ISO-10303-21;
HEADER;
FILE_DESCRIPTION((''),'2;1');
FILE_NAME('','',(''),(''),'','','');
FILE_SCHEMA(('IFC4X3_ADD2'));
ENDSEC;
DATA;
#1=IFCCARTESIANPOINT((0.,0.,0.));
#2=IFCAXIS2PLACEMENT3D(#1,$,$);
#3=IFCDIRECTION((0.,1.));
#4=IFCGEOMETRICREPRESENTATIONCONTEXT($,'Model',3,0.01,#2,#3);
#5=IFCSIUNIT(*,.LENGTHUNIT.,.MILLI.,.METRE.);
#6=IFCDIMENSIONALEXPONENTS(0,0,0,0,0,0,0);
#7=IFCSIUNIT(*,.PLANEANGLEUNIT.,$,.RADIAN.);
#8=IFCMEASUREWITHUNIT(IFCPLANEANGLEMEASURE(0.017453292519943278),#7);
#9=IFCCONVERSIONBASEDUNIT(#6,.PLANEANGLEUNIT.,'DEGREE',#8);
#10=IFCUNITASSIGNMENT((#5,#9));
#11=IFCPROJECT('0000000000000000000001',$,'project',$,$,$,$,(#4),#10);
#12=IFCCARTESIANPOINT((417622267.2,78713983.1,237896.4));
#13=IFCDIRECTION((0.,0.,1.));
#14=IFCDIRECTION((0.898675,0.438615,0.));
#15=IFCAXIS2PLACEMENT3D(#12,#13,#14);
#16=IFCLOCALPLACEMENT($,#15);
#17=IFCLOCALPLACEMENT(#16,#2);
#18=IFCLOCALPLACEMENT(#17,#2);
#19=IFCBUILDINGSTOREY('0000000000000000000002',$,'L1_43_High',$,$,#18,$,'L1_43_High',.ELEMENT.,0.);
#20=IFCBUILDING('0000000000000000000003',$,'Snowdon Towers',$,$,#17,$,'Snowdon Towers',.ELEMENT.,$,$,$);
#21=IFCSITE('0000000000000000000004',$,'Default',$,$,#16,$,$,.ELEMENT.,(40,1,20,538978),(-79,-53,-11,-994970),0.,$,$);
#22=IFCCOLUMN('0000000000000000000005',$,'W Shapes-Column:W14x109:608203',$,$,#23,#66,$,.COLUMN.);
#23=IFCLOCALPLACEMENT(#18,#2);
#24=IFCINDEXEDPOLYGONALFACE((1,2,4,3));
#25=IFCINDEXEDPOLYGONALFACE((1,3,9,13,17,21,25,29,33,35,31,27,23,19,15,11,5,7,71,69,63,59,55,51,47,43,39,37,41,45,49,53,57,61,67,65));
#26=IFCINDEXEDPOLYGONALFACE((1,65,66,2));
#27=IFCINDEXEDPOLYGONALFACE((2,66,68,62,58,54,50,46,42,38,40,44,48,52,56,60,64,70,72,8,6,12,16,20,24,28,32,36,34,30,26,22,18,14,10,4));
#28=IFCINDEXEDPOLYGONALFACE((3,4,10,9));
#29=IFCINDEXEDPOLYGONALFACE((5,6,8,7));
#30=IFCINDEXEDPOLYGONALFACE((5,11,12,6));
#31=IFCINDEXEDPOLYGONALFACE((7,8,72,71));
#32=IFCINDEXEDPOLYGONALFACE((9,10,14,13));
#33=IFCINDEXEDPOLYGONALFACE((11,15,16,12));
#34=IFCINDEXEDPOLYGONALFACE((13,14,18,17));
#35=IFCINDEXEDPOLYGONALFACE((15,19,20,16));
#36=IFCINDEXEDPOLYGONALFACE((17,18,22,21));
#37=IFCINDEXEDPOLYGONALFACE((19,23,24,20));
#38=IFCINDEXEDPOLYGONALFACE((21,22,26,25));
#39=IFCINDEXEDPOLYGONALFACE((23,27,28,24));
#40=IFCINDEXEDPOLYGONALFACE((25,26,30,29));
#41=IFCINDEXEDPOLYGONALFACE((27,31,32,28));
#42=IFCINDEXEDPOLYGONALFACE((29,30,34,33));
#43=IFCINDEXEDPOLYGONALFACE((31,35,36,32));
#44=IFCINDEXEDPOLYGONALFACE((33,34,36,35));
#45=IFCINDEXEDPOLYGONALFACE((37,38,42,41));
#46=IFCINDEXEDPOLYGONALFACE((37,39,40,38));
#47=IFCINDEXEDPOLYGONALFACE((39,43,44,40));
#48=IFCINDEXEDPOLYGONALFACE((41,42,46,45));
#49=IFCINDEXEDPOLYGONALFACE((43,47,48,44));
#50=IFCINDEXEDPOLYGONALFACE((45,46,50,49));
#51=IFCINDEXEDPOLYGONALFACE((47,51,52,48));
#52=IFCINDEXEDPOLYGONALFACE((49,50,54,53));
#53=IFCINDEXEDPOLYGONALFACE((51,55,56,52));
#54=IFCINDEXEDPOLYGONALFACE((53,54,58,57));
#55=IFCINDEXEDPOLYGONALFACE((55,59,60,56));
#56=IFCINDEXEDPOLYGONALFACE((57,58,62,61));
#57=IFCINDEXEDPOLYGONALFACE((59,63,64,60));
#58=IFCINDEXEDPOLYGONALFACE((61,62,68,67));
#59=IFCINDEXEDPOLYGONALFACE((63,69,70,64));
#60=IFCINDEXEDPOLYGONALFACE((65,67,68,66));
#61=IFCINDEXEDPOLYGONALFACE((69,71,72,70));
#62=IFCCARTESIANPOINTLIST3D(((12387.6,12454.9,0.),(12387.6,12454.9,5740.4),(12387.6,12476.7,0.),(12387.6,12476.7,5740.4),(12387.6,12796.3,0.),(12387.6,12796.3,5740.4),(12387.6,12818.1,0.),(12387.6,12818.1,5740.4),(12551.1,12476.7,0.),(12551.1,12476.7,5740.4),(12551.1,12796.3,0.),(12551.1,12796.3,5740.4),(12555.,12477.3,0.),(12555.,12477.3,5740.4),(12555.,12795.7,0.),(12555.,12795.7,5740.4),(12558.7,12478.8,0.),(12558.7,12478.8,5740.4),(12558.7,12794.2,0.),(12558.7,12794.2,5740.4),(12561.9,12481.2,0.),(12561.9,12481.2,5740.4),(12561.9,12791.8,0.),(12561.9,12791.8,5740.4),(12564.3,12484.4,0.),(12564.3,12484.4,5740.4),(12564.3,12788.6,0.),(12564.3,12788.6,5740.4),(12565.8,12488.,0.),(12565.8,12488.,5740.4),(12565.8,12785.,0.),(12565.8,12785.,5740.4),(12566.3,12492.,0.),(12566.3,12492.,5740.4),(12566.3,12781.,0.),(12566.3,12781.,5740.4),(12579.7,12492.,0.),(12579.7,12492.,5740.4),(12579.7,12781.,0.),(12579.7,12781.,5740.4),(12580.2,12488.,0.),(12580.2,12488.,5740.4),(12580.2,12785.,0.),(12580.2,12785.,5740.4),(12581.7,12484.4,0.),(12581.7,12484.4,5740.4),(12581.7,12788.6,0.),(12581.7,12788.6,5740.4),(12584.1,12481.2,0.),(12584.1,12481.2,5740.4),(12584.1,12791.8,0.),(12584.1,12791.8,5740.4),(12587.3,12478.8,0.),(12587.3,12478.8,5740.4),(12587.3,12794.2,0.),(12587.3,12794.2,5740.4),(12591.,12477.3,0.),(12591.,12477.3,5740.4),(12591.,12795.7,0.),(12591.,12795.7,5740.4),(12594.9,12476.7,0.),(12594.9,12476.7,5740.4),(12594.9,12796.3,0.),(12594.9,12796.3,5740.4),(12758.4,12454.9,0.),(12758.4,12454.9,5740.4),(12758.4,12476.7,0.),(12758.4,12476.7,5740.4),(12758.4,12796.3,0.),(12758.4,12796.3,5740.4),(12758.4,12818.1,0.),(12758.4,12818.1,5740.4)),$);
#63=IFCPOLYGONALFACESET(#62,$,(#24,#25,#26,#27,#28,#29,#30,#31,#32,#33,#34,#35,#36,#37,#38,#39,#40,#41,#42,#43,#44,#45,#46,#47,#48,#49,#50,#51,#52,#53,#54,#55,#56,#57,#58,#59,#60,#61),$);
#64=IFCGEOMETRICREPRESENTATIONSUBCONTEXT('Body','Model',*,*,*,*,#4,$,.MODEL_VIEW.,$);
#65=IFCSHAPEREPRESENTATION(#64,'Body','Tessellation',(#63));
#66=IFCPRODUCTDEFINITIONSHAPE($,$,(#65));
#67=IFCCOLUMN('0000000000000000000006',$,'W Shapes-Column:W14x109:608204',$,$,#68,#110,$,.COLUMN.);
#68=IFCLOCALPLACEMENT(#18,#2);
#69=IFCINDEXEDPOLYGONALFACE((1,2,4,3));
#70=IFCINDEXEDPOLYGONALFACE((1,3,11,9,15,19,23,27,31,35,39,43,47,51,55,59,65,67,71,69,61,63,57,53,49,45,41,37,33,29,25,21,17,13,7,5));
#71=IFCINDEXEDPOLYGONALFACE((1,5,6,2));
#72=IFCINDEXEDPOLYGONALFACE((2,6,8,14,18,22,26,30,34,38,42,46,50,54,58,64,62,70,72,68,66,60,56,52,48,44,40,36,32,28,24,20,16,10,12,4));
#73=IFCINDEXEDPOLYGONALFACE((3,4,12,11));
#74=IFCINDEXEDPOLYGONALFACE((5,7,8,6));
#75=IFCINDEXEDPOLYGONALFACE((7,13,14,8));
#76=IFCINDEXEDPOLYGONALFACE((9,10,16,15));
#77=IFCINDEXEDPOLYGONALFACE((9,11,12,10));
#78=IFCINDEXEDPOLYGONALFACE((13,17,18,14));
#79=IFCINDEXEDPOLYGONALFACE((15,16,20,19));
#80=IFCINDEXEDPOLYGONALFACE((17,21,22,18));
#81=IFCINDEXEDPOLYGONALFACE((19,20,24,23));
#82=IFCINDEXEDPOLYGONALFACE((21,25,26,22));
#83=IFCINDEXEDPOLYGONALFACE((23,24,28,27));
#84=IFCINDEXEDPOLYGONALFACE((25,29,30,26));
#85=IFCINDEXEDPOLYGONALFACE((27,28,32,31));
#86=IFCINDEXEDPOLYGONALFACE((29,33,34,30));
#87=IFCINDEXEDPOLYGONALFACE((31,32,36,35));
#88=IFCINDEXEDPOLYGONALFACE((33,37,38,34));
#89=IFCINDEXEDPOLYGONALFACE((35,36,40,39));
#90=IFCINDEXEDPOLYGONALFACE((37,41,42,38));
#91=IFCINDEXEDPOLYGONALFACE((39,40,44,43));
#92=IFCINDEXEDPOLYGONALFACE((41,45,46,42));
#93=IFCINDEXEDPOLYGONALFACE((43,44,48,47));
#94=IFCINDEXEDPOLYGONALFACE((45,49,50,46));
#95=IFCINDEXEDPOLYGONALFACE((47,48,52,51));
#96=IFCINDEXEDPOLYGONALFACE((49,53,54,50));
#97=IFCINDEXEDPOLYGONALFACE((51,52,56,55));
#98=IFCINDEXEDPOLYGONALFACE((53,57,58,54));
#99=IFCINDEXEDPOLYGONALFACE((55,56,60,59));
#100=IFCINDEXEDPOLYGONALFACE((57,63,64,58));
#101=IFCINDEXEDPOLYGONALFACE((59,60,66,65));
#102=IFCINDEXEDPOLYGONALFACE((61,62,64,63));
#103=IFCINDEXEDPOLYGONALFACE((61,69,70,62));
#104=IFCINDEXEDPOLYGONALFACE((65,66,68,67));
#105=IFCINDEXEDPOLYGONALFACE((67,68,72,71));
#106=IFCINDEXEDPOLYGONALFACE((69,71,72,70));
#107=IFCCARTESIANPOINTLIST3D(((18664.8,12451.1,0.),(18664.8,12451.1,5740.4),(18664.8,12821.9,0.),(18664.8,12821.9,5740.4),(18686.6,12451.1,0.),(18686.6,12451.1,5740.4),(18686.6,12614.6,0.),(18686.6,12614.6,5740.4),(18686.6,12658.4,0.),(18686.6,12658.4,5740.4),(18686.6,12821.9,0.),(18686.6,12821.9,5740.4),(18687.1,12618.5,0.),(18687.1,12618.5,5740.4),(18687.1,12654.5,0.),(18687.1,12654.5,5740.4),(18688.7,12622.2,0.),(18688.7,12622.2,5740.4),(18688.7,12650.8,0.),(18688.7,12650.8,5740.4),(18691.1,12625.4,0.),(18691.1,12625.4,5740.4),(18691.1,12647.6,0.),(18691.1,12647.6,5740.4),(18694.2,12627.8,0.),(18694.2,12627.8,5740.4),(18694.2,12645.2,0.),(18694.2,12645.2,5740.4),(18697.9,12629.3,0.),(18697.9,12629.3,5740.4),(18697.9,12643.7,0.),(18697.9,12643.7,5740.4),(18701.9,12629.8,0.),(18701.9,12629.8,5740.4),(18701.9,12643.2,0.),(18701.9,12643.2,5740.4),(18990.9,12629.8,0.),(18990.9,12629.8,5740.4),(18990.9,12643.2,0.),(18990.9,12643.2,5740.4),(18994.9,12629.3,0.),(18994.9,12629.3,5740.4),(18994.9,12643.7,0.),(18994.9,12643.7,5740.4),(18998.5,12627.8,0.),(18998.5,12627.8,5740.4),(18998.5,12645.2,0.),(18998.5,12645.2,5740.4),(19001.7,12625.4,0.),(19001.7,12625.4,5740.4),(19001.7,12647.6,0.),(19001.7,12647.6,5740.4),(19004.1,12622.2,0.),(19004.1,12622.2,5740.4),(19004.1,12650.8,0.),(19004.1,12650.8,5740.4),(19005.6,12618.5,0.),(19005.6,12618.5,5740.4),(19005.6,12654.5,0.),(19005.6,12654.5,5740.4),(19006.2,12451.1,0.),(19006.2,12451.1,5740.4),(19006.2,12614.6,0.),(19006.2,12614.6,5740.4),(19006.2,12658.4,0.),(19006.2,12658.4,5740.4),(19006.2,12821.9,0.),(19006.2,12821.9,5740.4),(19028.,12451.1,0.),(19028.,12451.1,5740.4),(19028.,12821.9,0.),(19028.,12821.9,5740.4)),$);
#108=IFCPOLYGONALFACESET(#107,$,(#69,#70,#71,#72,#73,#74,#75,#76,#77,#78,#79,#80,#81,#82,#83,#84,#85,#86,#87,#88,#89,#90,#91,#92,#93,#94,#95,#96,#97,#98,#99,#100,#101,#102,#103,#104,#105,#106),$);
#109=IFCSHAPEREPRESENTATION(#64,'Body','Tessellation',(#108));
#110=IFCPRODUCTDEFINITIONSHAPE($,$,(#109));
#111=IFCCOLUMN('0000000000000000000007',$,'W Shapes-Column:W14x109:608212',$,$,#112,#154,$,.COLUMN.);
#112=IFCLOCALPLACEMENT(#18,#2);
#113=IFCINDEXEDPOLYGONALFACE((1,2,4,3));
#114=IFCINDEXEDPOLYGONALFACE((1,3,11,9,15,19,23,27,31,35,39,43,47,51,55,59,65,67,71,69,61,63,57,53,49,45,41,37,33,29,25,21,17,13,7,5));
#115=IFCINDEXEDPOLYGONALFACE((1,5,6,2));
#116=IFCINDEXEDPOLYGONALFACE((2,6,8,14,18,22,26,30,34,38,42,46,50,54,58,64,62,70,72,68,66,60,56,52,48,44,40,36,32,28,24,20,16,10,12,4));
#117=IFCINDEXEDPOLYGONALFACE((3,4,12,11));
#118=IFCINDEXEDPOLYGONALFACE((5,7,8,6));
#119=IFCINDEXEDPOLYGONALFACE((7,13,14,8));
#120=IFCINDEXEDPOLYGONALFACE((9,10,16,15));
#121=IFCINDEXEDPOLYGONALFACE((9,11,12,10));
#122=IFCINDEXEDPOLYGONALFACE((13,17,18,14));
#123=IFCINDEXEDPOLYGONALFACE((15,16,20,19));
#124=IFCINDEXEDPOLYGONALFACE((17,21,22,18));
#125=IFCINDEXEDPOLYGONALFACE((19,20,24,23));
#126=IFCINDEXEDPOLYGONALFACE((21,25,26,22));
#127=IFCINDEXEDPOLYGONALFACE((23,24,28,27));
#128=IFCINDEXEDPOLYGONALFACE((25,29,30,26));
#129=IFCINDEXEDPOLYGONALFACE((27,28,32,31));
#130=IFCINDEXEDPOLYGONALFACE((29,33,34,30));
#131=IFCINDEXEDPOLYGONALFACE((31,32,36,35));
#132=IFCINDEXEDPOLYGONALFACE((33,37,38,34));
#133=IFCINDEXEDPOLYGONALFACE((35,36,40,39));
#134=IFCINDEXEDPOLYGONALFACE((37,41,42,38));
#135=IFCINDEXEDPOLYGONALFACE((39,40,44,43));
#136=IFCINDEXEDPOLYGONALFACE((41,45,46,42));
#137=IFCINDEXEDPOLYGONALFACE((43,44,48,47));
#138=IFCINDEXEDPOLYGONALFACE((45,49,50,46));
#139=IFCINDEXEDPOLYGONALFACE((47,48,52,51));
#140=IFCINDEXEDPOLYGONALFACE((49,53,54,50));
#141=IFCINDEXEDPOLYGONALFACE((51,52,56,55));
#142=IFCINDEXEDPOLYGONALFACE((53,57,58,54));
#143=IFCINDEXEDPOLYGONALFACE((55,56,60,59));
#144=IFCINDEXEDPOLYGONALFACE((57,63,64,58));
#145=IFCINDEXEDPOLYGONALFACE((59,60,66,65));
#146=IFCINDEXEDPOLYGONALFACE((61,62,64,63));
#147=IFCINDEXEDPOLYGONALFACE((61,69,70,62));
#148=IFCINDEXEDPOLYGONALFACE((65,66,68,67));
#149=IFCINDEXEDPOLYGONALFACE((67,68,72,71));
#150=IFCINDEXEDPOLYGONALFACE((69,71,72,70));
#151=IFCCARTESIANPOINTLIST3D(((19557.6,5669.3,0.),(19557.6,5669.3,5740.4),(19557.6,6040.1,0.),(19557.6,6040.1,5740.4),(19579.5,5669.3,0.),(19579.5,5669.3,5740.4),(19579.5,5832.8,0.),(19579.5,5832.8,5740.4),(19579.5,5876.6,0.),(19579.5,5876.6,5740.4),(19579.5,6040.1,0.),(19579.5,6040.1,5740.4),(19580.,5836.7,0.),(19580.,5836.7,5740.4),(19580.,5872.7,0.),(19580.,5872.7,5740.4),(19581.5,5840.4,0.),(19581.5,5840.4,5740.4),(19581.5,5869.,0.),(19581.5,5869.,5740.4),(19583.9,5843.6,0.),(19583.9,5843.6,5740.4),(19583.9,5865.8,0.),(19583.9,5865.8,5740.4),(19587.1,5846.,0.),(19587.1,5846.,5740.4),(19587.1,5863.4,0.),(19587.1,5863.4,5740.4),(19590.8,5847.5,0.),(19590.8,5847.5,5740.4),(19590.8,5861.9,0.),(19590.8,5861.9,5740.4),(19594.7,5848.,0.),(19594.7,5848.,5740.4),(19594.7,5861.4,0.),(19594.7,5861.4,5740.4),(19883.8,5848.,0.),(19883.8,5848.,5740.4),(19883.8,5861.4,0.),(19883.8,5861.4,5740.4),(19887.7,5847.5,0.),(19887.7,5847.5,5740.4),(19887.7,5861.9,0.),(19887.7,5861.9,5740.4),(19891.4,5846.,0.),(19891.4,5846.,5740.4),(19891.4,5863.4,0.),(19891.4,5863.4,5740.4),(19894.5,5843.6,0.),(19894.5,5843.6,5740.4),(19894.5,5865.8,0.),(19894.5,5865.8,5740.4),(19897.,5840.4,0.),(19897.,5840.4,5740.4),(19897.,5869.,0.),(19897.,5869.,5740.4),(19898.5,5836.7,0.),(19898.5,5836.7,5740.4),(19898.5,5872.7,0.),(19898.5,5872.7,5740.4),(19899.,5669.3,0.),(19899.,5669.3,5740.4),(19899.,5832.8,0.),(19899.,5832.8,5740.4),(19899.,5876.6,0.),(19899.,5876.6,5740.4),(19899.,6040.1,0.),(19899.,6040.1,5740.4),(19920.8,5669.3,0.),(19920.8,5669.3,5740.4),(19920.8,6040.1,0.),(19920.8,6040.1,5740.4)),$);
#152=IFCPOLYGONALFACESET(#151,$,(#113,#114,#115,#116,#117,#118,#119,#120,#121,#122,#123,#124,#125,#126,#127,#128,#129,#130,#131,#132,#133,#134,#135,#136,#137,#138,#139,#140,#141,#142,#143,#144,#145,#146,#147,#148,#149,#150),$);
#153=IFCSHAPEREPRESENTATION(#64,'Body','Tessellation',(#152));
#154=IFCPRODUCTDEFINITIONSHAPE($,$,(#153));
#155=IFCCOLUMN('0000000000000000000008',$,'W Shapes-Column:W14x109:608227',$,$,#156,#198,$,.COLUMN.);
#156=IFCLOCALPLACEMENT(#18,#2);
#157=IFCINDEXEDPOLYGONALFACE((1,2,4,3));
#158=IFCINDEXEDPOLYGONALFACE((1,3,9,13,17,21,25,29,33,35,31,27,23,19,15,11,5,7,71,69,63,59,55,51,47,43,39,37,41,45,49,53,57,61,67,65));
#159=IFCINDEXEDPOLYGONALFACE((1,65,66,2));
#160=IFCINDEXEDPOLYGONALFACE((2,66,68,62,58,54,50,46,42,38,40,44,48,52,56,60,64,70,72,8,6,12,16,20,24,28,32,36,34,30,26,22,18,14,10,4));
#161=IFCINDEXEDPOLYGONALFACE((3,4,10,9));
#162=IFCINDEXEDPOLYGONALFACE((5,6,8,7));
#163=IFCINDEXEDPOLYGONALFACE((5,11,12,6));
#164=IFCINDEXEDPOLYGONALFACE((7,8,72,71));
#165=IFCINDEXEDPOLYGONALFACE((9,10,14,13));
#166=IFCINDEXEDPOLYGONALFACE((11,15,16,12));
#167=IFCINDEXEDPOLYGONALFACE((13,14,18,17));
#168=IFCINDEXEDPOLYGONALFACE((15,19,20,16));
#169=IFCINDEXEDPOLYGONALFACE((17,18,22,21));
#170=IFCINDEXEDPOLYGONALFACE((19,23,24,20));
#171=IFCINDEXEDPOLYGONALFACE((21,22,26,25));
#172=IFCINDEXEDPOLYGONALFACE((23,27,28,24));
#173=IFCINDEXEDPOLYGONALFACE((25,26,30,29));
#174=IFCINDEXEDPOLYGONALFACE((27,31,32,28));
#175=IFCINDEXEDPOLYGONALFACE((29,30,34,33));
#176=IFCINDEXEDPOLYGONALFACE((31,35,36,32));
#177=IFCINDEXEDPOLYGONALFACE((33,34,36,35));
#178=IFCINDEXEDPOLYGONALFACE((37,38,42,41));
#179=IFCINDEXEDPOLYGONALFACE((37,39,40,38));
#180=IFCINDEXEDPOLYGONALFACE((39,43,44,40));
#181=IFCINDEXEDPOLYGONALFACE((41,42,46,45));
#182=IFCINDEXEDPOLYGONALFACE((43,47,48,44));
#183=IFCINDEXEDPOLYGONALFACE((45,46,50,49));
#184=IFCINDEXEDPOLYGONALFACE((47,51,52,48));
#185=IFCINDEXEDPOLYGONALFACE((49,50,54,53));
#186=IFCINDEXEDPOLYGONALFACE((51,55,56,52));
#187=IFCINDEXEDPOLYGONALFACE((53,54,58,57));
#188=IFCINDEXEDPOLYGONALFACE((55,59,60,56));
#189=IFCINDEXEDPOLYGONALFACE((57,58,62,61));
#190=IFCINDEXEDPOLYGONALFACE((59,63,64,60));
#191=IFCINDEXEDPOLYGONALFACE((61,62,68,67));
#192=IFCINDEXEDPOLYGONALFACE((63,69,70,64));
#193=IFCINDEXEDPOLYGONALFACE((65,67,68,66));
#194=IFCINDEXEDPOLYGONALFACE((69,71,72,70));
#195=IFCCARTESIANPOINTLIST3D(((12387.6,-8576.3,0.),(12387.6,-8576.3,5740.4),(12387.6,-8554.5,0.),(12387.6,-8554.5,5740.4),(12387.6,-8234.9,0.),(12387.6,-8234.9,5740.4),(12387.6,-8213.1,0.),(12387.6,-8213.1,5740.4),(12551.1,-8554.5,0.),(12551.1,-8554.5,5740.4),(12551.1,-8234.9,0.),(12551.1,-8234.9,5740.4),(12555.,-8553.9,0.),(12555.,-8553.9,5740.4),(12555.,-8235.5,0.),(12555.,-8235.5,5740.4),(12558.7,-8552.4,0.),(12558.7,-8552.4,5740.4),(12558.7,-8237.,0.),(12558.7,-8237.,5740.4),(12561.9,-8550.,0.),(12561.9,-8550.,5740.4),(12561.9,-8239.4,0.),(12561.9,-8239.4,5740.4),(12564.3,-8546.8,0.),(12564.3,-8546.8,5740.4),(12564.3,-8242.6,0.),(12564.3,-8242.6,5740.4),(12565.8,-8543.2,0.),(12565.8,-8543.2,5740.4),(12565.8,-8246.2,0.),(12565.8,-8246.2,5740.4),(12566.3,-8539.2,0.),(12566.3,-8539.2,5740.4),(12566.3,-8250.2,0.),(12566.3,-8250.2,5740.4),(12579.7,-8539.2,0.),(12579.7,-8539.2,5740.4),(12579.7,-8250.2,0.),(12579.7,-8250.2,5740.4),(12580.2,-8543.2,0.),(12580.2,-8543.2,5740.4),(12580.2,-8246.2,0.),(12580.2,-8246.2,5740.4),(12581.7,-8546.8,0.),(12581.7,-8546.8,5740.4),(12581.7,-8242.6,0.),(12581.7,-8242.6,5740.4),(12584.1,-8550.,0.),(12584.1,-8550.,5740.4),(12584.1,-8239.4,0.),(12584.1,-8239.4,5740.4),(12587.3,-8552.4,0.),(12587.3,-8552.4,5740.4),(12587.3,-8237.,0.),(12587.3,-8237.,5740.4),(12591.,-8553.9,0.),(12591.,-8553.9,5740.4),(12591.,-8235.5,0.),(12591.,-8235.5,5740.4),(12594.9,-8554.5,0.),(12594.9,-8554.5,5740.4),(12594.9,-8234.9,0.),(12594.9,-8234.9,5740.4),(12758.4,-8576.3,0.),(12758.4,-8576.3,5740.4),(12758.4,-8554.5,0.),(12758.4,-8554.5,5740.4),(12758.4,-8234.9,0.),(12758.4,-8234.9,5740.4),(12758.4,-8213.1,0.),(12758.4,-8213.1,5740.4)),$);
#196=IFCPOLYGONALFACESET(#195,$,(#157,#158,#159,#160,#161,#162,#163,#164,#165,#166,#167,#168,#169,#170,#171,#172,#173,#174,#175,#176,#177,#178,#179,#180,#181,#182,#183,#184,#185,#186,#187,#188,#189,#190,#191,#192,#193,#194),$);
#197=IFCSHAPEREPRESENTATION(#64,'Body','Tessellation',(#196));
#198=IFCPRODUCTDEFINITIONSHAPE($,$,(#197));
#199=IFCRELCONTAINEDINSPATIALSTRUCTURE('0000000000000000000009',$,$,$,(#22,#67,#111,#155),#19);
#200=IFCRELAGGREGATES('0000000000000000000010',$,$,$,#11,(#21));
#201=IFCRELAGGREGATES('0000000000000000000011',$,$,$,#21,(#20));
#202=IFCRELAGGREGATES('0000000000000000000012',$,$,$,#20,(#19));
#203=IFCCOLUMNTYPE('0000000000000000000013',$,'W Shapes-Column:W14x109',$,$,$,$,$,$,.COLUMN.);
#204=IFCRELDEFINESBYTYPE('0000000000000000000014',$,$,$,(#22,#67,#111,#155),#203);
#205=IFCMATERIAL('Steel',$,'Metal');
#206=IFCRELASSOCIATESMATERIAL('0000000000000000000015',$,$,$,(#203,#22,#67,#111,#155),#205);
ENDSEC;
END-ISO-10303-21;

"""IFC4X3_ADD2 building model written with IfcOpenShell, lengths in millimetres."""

from ifc_helpers import new_model, entity, si_unit, converted_unit, direction, frame, frame_2d, origin, place, context, subcontext, project, spatial, i_section, extrude, source, transform, mapped, material, material_profile, profile_set, profile_usage, type_object, type_shapes, element, save


model = new_model("IFC4X3_ADD2")

# Units and contexts
model_context = context("Model", 3, precision=0.01, world=origin(), true_north=direction((0.0, 1.0)))
body_context = subcontext(model_context, "Body", "Model", "MODEL_VIEW")
ifc_project = project(units=[si_unit("LENGTHUNIT", "METRE", prefix="MILLI"), converted_unit("PLANEANGLEUNIT", "DEGREE", entity("IfcPlaneAngleMeasure", 0.017453292519943278), si_unit("PLANEANGLEUNIT", "RADIAN"), dimensions=[0, 0, 0, 0, 0, 0, 0])], contexts=[model_context])

# Site, building, storey
site_placement = place(None, frame((417622267.2, 78713983.1, 237896.4), z_axis=(0.0, 0.0, 1.0), x_axis=(0.898675, 0.438615, 0.0)))
site = spatial("IfcSite", under=ifc_project, at=site_placement, Name="Default", CompositionType="ELEMENT", RefLatitude=(40, 1, 20, 538978), RefLongitude=(-79, -53, -11, -994970), RefElevation=0.0)
building_placement = place(site_placement, origin())
building = spatial("IfcBuilding", under=site, at=building_placement, Name="Snowdon Towers", LongName="Snowdon Towers", CompositionType="ELEMENT")
storey_placement = place(building_placement, origin())
storey = spatial("IfcBuildingStorey", under=building, at=storey_placement, Name="L1_43_High", LongName="L1_43_High", CompositionType="ELEMENT", Elevation=0.0)

# Columns
ifc_material_1 = material(Name="Steel", Category="Metal")
ifc_material_profile_1 = material_profile(ifc_material_1, i_section(OverallWidth=370.8, OverallDepth=363.2, WebThickness=13.3, FlangeThickness=21.8, FilletRadius=15.2, at=frame_2d((0.0, 0.0), x_axis=(1.0, 0.0))), Name="W14x109")
ifc_profile_set_1 = profile_set([ifc_material_profile_1], Name="W14x109")
ifc_profile_usage_1 = profile_usage(ifc_profile_set_1)
column_type_1 = type_object("IfcColumnType", Name="W Shapes-Column:W14x109", PredefinedType="COLUMN", material=ifc_profile_set_1)
shared_shape_1 = source(origin(), body_context, "Body", "SweptSolid", [
    extrude(i_section(OverallWidth=370.8, OverallDepth=363.2, WebThickness=13.3, FlangeThickness=21.8, FilletRadius=15.2, at=frame_2d((0.0, 0.0), x_axis=(1.0, 0.0))), frame((0.0, 0.0, 0.0), z_axis=(0.0, 0.0, 1.0), x_axis=(-1.0, 0.0, 0.0)), (0.0, 0.0, 1.0), 5740.4),
])
type_shapes(column_type_1, [shared_shape_1])
for number, where, z_axis, x_axis, name in (
    (1, (12573.0, 12636.5, 0.0), (0.0, 0.0, 1.0), (-1.0, 0.0, 0.0), "W Shapes-Column:W14x109:608203"),
    (2, (18846.4, 12636.5, 0.0), (0.0, 0.0, 1.0), (0.0, 1.0, 0.0), "W Shapes-Column:W14x109:608204"),
    (3, (19739.2, 5854.7, 0.0), (0.0, 0.0, 1.0), (0.0, 1.0, 0.0), "W Shapes-Column:W14x109:608212"),
    (4, (12573.0, -8394.7, 0.0), (0.0, 0.0, 1.0), (-1.0, 0.0, 0.0), "W Shapes-Column:W14x109:608227"),
):
    element("IfcColumn", number, at=place(storey_placement, frame(where, z_axis=z_axis, x_axis=x_axis)), inside=storey, type_object=column_type_1, material=ifc_profile_usage_1, Name=name, PredefinedType="COLUMN", context=body_context, shape_type="MappedRepresentation", body=[
        mapped(shared_shape_1, transform((0.0, 0.0, 0.0), scale=1.0)),
    ])

save(model, "model.ifc")
